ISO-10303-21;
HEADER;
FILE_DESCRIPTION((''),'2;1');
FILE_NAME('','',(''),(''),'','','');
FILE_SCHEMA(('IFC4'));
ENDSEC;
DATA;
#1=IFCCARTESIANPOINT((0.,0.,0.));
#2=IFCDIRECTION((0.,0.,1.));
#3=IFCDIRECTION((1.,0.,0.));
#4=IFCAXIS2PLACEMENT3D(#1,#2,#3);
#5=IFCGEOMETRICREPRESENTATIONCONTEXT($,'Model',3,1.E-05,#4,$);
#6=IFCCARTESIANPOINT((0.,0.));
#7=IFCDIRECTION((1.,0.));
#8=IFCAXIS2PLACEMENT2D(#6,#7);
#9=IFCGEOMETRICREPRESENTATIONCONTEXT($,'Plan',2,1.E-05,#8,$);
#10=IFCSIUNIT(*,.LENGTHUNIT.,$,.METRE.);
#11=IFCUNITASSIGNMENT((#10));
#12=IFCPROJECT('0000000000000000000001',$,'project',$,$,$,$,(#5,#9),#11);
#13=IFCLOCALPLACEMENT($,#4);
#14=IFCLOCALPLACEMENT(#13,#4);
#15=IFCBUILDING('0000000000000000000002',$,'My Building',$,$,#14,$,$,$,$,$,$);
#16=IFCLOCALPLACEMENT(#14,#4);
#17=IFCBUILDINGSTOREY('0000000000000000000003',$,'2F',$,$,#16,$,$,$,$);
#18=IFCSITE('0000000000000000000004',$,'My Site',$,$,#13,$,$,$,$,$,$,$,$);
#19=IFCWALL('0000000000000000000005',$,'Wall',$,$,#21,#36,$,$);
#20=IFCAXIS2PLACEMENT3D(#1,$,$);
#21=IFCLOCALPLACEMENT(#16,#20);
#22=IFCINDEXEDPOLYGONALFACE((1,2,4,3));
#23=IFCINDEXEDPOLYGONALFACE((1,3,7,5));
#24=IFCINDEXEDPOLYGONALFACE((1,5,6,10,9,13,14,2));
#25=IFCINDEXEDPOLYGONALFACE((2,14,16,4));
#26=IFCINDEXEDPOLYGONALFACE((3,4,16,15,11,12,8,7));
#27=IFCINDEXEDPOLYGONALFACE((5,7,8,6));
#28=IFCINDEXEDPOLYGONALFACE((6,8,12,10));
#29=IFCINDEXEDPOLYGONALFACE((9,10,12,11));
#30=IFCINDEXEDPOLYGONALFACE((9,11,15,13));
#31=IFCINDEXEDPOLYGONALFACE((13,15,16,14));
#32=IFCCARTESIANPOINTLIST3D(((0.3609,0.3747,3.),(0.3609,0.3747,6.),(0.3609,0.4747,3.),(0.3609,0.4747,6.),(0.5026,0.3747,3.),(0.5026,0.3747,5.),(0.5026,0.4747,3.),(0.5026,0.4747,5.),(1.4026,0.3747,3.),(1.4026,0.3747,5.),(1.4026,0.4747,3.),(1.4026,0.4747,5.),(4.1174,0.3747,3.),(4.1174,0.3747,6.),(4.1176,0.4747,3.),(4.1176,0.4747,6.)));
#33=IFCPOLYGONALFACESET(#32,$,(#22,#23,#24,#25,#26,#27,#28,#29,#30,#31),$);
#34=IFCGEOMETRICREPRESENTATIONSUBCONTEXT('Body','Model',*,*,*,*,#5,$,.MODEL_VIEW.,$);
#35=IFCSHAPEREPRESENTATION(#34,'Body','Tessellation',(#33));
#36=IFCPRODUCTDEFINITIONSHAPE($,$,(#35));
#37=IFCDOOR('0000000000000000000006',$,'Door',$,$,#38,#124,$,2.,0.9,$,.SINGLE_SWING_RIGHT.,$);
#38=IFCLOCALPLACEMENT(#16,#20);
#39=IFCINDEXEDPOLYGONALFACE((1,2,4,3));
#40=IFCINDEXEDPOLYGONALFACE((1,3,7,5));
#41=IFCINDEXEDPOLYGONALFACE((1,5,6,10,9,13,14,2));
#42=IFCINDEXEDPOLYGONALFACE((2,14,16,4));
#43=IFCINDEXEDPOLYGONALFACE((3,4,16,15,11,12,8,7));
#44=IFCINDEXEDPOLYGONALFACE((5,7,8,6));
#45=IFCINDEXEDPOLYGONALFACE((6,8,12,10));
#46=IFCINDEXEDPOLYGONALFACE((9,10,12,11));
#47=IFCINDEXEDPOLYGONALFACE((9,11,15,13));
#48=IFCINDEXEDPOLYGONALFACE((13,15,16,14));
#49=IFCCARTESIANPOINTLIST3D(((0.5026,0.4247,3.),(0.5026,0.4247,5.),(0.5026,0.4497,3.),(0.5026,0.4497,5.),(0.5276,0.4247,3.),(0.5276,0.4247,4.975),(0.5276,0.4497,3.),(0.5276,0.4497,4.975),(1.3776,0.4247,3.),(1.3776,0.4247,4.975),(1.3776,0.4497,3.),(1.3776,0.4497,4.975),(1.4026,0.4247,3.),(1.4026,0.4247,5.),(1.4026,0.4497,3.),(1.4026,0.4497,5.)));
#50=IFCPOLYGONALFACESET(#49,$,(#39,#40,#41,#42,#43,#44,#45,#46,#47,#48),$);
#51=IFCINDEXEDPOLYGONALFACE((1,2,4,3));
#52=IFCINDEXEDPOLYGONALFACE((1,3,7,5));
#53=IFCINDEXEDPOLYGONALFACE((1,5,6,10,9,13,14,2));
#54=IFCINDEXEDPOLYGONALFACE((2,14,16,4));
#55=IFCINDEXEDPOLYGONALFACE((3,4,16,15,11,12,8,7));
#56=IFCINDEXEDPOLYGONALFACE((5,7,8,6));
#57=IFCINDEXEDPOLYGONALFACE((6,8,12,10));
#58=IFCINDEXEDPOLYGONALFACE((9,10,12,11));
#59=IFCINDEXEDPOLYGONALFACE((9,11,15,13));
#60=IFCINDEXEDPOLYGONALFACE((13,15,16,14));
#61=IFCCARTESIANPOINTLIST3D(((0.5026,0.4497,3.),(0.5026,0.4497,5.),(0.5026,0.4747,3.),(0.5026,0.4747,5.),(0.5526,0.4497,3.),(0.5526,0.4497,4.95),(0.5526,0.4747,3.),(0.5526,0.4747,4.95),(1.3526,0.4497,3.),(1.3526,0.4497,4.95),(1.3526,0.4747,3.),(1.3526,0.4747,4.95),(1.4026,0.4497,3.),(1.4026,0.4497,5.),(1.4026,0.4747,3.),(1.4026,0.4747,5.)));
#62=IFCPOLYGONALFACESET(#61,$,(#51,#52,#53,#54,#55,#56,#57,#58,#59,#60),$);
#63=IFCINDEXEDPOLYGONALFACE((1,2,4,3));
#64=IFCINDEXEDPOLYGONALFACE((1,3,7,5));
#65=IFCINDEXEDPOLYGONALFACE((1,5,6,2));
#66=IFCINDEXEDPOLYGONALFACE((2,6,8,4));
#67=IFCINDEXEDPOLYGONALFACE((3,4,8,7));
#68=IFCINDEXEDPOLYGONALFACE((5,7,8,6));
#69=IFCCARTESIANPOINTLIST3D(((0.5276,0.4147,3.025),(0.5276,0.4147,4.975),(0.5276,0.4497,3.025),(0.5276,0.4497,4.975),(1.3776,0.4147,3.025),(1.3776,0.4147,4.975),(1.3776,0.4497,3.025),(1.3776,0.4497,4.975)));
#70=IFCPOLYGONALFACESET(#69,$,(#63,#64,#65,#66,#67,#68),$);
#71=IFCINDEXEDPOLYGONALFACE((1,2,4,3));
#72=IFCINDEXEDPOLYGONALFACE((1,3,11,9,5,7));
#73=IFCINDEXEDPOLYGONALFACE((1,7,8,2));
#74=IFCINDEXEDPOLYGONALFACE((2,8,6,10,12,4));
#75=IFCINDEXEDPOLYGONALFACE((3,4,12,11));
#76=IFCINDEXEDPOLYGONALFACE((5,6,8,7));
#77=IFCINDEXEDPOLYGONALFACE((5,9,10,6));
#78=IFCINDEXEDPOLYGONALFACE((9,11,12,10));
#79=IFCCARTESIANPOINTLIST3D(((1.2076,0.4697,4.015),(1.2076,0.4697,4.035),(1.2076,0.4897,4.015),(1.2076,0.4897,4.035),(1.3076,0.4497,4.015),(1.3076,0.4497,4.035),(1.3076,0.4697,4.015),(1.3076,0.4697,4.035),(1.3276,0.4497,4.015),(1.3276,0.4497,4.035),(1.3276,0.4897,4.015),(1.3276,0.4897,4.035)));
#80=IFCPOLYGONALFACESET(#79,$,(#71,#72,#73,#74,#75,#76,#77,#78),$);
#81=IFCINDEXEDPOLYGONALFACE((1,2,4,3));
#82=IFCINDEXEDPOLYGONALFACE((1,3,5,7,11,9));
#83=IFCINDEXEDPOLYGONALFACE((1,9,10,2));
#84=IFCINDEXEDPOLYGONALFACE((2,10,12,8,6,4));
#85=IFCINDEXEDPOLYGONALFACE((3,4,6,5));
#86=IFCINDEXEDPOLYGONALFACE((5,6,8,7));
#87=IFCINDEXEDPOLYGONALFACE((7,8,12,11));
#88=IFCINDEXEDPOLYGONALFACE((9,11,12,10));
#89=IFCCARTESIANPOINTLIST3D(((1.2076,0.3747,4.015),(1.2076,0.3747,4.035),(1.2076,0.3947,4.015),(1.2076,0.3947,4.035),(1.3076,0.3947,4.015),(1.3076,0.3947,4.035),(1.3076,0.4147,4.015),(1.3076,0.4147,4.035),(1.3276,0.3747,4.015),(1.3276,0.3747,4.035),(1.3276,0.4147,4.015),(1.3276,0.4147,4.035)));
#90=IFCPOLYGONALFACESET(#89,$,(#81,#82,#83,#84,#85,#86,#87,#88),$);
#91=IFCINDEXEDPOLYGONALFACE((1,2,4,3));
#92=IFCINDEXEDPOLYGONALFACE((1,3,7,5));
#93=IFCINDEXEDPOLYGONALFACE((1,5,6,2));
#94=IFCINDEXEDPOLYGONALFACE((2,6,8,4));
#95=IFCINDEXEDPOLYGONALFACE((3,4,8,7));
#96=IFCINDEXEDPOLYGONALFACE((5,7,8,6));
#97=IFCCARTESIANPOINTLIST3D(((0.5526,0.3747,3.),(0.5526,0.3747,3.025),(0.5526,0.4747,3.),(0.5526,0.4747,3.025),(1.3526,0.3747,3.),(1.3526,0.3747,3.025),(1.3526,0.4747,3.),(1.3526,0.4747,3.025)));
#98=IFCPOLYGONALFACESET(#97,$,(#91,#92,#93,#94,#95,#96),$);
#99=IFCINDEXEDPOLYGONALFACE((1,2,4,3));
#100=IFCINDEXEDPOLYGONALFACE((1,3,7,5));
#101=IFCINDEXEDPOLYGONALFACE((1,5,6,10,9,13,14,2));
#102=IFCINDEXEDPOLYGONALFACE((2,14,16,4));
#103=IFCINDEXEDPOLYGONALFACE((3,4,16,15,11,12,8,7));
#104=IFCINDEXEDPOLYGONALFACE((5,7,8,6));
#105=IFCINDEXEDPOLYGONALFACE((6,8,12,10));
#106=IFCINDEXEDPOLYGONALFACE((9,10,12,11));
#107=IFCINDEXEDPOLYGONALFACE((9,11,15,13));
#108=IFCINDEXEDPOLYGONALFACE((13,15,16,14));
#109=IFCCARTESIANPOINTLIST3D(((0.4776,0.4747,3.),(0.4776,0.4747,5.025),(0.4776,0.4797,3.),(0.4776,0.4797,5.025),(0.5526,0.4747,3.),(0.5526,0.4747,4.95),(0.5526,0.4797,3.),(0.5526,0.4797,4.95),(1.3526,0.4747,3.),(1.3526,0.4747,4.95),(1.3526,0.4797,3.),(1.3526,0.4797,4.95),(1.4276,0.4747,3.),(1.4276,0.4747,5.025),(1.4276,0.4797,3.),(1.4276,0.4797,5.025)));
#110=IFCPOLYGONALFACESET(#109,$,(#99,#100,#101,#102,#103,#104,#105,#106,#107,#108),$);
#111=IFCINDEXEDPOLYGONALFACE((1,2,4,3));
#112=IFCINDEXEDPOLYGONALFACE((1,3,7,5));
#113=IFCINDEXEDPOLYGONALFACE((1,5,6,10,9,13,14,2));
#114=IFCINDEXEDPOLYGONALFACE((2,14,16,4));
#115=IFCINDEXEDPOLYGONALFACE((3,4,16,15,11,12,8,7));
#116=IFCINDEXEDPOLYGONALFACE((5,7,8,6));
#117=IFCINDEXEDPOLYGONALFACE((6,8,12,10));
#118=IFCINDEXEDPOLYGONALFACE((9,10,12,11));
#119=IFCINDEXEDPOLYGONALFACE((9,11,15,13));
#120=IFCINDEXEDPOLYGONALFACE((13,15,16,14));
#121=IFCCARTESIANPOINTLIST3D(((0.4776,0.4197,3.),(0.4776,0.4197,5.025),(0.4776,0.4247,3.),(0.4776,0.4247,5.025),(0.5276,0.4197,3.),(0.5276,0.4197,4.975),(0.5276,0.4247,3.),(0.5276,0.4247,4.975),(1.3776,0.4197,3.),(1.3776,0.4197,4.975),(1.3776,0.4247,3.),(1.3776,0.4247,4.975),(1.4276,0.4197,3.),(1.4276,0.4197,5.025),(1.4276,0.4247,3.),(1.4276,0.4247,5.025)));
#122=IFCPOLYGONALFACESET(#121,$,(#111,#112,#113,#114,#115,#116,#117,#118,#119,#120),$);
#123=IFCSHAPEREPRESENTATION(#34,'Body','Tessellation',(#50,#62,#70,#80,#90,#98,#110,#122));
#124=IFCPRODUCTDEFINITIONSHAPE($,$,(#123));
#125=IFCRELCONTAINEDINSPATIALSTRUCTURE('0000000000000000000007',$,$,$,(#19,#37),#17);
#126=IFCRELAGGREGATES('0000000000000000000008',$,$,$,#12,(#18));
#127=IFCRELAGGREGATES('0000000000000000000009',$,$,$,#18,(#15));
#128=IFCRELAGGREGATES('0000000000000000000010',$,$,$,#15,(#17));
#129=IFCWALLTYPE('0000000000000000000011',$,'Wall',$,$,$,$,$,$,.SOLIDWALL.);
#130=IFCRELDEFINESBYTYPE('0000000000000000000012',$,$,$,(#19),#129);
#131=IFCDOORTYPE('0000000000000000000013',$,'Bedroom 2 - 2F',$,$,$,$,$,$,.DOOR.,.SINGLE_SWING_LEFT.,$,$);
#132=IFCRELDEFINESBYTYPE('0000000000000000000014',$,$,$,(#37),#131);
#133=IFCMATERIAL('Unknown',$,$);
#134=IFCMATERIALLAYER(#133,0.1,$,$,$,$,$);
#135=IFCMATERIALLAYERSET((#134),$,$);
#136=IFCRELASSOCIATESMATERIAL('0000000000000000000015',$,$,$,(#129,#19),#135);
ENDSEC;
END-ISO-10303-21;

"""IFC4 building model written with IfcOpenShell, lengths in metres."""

from ifc_helpers import new_model, entity, si_unit, frame, origin_with_axes, origin_2d_with_axis, place, context, subcontext, project, spatial, line, indexed_curve, outline, extrude, shape, source, transform, mapped, material, layer, layer_set, layer_usage, type_object, type_shapes, element, fill, save


model = new_model("IFC4")

# Units and contexts
model_context = context("Model", 3, precision=1e-05, world=origin_with_axes())
plan_context = context("Plan", 2, precision=1e-05, world=origin_2d_with_axis())
body_context_1 = subcontext(model_context, "Body", "Model", "MODEL_VIEW")
body_context_2 = subcontext(plan_context, "Body", "Plan", "PLAN_VIEW")
ifc_project = project(units=[si_unit("LENGTHUNIT", "METRE")], contexts=[model_context, plan_context])

# Site, building, storey
site_placement = place(None, origin_with_axes())
site = spatial("IfcSite", under=ifc_project, at=site_placement, Name="My Site")
building_placement = place(site_placement, origin_with_axes())
building = spatial("IfcBuilding", under=site, at=building_placement, Name="My Building")
storey_placement = place(building_placement, origin_with_axes())
storey = spatial("IfcBuildingStorey", under=building, at=storey_placement, Name="2F")

# Shared definitions
ifc_material = material(Name="Unknown")
ifc_layer = layer(ifc_material, 0.1)
ifc_layer_set = layer_set([ifc_layer])
wall_type = type_object("IfcWallType", Name="Wall", PredefinedType="SOLIDWALL", material=ifc_layer_set)

# Wall, opening, door
ifc_layer_usage_1 = layer_usage(ifc_layer_set, "AXIS2", "POSITIVE", 0.0)
wall_1_placement = place(storey_placement, frame((0.2609, 0.3747, 3.0), z_axis=(0.0, 0.0, 1.0), x_axis=(1.0, 0.0, 0.0)))
wall_1 = element("IfcWall", 1, at=wall_1_placement, inside=storey, type_object=wall_type, material=ifc_layer_usage_1, Name="Wall", context=body_context_1, shape_type="SweptSolid", body=[
    extrude(outline(indexed_curve([(0.1, 0.0), (0.1, 0.1), (3.8567, 0.1), (3.8565, 0.0)], segments=[line(1, 2, 3, 4, 1)])), origin_with_axes(), (0.0, 0.0, 1.0), 3.0),
])
shared_shape_1 = source(origin_with_axes(), body_context_1, "Body", "SweptSolid", [
    extrude(outline(indexed_curve([(0.0, 0.0), (0.9, 0.0), (0.9, 2.0), (0.0, 2.0)], segments=[line(1, 2, 3, 4, 1)])), frame((0.0, -0.6, 0.0), z_axis=(0.0, -1.0, 0.0), x_axis=(1.0, 0.0, 0.0)), (0.0, 0.0, -1.0), 1.2),
])
opening_1_placement = place(wall_1_placement, frame((1.1417, 0.1, 0.0), z_axis=(0.0, 0.0, 1.0), x_axis=(-1.0, 0.0, 0.0)))
opening_1 = element("IfcOpeningElement", 2, at=opening_1_placement, cuts=wall_1, PredefinedType="OPENING", context=body_context_1, shape_type="MappedRepresentation", body=[
    mapped(shared_shape_1, transform((0.0, 0.0, 0.0), x_axis=(1.0, 0.0, 0.0), y_axis=(0.0, 1.0, 0.0), z_axis=(0.0, 0.0, 1.0), scale=1.0)),
])
door_type_1 = type_object("IfcDoorType", Name="Bedroom 2 - 2F", OperationType="SINGLE_SWING_LEFT", PredefinedType="DOOR")
shared_shape_2 = source(origin_with_axes(), body_context_1, "Body", "SweptSolid", [
    extrude(outline(indexed_curve([(0.0, 0.0), (0.0, 2.0), (0.9, 2.0), (0.9, 0.0), (0.875, 0.0), (0.875, 1.975), (0.025, 1.975), (0.025, 0.0)], segments=[line(1, 2, 3, 4, 5, 6, 7, 8, 1)])), frame((0.0, 0.025, 0.0), z_axis=(0.0, -1.0, 0.0), x_axis=(1.0, 0.0, 0.0)), (0.0, 0.0, -1.0), 0.025),
    extrude(outline(indexed_curve([(0.0, 0.0), (0.0, 2.0), (0.9, 2.0), (0.9, 0.0), (0.85, 0.0), (0.85, 1.95), (0.05, 1.95), (0.05, 0.0)], segments=[line(1, 2, 3, 4, 5, 6, 7, 8, 1)])), frame((0.0, 0.0, 0.0), z_axis=(0.0, -1.0, 0.0), x_axis=(1.0, 0.0, 0.0)), (0.0, 0.0, -1.0), 0.025),
    extrude(outline(indexed_curve([(0.0, 0.0), (0.85, 0.0), (0.85, 0.035), (0.0, 0.035)], segments=[line(1, 2, 3, 4, 1)])), frame((0.025, 0.025, 0.025), z_axis=(0.0, 0.0, 1.0), x_axis=(1.0, 0.0, 0.0)), (0.0, 0.0, 1.0), 1.95),
    extrude(outline(indexed_curve([(0.0, 0.0), (0.0, -0.04), (0.12, -0.04), (0.12, -0.02), (0.02, -0.02), (0.02, 0.0)], segments=[line(1, 2, 3, 4, 5, 6, 1)])), frame((0.075, 0.025, 1.015), z_axis=(0.0, 0.0, 1.0), x_axis=(1.0, 0.0, 0.0)), (0.0, 0.0, 1.0), 0.02),
    extrude(outline(indexed_curve([(0.0, 0.0), (0.0, 0.04), (0.12, 0.04), (0.12, 0.02), (0.02, 0.02), (0.02, 0.0)], segments=[line(1, 2, 3, 4, 5, 6, 1)])), frame((0.075, 0.06, 1.015), z_axis=(0.0, 0.0, 1.0), x_axis=(1.0, 0.0, 0.0)), (0.0, 0.0, 1.0), 0.02),
    extrude(outline(indexed_curve([(0.0, 0.0), (0.8, 0.0), (0.8, 0.1), (0.0, 0.1)], segments=[line(1, 2, 3, 4, 1)])), frame((0.05, 0.0, 0.0), z_axis=(0.0, 0.0, 1.0), x_axis=(1.0, 0.0, 0.0)), (0.0, 0.0, 1.0), 0.025),
    extrude(outline(indexed_curve([(0.0, 0.0), (0.0, 2.025), (0.95, 2.025), (0.95, 0.0), (0.875, 0.0), (0.875, 1.95), (0.075, 1.95), (0.075, 0.0)], segments=[line(1, 2, 3, 4, 5, 6, 7, 8, 1)])), frame((-0.025, -0.005, 0.0), z_axis=(0.0, -1.0, 0.0), x_axis=(1.0, 0.0, 0.0)), (0.0, 0.0, -1.0), 0.005),
    extrude(outline(indexed_curve([(0.0, 0.0), (0.0, 2.025), (0.95, 2.025), (0.95, 0.0), (0.9, 0.0), (0.9, 1.975), (0.05, 1.975), (0.05, 0.0)], segments=[line(1, 2, 3, 4, 5, 6, 7, 8, 1)])), frame((-0.025, 0.05, 0.0), z_axis=(0.0, -1.0, 0.0), x_axis=(1.0, 0.0, 0.0)), (0.0, 0.0, -1.0), 0.005),
])
shared_shape_3 = source(origin_with_axes(), body_context_2, "Body", "Curve2D", [
    entity("IfcIndexedPolyCurve", entity("IfcCartesianPointList2D", [[0.0, 0.0], [0.0, 0.05], [0.025, 0.05], [0.025, 0.025], [0.05, 0.025], [0.05, 0.0]]), [entity("IfcLineIndex", [1, 2, 3, 4, 5, 6, 1])]),
    entity("IfcIndexedPolyCurve", entity("IfcCartesianPointList2D", [[0.9, 0.0], [0.9, 0.05], [0.875, 0.05], [0.875, 0.025], [0.85, 0.025], [0.85, 0.0]]), [entity("IfcLineIndex", [1, 2, 3, 4, 5, 6, 1])]),
    entity("IfcTrimmedCurve", entity("IfcEllipse", entity("IfcAxis2Placement2D", entity("IfcCartesianPoint", [0.84, 0.05]), entity("IfcDirection", [1.0, 0.0])), 0.815, 0.85), [entity("IfcCartesianPoint", [0.84, 0.9])], [entity("IfcCartesianPoint", [0.025, 0.05])], True, "CARTESIAN"),
    entity("IfcIndexedPolyCurve", entity("IfcCartesianPointList2D", [[0.875, 0.05], [0.84, 0.05], [0.84, 0.9], [0.875, 0.9]]), [entity("IfcLineIndex", [1, 2, 3, 4, 1])]),
])
type_shapes(door_type_1, [shared_shape_2, shared_shape_3])
door_1_placement = place(opening_1_placement, origin_with_axes())
door_1 = element("IfcDoor", 3, at=door_1_placement, inside=storey, type_object=door_type_1, Name="Door", OperationType="SINGLE_SWING_RIGHT", OverallHeight=2.0, OverallWidth=0.9, shapes=[
    shape(body_context_1, "Body", "MappedRepresentation", [mapped(shared_shape_2, transform((0.0, 0.0, 0.0), x_axis=(1.0, 0.0, 0.0), y_axis=(0.0, 1.0, 0.0), z_axis=(0.0, 0.0, 1.0), scale=1.0))]),
    shape(body_context_2, "Body", "MappedRepresentation", [mapped(shared_shape_3, transform((0.0, 0.0, 0.0), x_axis=(1.0, 0.0, 0.0), y_axis=(0.0, 1.0, 0.0), z_axis=(0.0, 0.0, 1.0), scale=1.0))]),
])
fill(opening_1, door_1)

save(model, "model.ifc")
